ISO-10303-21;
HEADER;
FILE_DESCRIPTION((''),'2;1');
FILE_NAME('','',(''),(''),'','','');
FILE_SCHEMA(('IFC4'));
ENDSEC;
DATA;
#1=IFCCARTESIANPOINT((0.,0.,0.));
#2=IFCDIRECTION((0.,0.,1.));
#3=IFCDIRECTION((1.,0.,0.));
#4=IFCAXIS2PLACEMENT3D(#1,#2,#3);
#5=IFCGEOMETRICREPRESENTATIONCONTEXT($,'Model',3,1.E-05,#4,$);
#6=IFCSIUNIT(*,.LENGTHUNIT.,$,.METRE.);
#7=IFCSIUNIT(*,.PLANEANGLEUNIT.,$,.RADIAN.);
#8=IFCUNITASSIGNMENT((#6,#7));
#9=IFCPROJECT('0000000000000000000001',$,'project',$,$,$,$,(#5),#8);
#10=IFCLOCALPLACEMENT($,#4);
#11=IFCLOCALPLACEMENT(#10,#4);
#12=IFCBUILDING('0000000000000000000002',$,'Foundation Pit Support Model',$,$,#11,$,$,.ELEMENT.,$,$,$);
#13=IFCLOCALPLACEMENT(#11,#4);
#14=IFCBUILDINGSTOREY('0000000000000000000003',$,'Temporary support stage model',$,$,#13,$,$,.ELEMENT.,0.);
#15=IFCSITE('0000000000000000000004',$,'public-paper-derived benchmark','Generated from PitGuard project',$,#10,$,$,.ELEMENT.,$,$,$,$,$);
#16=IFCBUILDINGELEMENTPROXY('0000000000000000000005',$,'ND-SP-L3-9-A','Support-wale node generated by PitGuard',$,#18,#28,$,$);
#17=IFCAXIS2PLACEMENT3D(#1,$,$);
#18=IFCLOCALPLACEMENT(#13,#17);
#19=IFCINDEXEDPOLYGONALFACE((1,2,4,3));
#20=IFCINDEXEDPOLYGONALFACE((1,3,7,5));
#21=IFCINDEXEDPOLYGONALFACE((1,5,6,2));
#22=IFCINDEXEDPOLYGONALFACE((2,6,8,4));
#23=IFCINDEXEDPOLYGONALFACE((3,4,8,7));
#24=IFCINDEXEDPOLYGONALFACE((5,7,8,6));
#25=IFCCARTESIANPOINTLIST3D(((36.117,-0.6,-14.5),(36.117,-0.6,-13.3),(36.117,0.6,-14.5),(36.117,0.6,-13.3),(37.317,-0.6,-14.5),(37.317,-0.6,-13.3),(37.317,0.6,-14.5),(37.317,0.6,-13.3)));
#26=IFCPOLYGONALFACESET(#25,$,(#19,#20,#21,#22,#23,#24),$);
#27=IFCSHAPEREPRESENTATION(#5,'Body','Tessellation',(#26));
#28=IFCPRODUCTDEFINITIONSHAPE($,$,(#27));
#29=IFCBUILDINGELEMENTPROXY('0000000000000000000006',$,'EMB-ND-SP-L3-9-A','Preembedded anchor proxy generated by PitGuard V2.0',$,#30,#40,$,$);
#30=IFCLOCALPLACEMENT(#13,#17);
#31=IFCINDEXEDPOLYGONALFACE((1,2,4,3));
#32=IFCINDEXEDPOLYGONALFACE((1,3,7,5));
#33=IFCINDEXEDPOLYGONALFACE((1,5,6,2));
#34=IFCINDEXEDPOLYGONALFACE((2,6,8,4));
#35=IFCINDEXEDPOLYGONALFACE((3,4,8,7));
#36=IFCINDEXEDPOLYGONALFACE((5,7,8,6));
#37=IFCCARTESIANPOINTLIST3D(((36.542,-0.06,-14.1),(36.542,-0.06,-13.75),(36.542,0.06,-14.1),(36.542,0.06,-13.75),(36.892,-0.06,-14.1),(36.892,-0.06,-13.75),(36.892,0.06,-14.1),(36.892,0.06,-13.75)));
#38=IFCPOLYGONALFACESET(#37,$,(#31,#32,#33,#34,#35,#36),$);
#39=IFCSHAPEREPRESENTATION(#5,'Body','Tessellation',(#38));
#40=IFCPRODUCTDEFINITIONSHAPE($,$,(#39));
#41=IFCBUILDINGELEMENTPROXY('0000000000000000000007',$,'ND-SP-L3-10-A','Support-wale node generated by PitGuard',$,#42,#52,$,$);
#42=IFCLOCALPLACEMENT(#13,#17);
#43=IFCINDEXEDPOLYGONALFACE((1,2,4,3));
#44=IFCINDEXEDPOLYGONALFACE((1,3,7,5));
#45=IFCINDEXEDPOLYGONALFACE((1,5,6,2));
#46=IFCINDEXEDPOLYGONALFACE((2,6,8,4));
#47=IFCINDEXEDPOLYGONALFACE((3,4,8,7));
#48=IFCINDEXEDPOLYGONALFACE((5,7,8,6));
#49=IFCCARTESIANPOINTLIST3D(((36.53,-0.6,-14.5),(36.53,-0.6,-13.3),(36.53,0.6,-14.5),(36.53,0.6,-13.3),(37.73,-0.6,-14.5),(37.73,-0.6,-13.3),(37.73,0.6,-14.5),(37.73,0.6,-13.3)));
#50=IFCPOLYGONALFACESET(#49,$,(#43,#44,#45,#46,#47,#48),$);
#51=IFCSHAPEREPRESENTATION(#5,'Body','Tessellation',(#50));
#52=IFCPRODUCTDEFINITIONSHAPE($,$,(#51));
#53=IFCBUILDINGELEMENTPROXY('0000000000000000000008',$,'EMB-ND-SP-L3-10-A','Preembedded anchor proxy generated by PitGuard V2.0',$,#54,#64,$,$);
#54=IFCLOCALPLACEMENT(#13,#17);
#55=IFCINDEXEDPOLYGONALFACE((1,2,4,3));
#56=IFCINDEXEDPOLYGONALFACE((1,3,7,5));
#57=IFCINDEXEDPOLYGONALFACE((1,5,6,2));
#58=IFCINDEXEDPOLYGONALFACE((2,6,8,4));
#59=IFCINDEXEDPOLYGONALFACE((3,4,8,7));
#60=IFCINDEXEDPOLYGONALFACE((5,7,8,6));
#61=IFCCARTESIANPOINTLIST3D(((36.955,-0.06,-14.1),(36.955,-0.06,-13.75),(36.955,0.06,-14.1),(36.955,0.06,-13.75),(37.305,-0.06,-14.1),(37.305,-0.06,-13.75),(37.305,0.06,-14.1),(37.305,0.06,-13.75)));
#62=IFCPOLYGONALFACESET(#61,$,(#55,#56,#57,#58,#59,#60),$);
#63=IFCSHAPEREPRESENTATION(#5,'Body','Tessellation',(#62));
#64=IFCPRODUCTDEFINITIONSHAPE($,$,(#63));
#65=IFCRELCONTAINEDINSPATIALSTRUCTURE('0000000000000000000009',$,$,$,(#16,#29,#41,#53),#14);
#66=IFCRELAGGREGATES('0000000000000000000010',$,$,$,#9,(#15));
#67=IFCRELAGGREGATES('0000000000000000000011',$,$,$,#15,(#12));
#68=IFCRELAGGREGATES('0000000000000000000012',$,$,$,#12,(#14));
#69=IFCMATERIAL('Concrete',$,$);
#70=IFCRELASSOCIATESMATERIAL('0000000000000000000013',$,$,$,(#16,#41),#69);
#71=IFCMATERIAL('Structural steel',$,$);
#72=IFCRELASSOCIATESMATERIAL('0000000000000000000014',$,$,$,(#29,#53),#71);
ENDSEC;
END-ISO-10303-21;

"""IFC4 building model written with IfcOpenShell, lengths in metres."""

from ifc_helpers import new_model, si_unit, frame, origin_with_axes, origin_2d, place, context, project, spatial, rectangle, extrude, material, element, save


model = new_model("IFC4")

# Units and contexts
model_context = context("Model", 3, precision=1e-05, world=origin_with_axes())
ifc_project = project(units=[si_unit("LENGTHUNIT", "METRE"), si_unit("PLANEANGLEUNIT", "RADIAN")], contexts=[model_context])

# Site, building, storey
site_placement = place(None, origin_with_axes())
site = spatial("IfcSite", under=ifc_project, at=site_placement, Name="public-paper-derived benchmark", Description="Generated from PitGuard project", CompositionType="ELEMENT")
building_placement = place(site_placement, origin_with_axes())
building = spatial("IfcBuilding", under=site, at=building_placement, Name="Foundation Pit Support Model", CompositionType="ELEMENT")
storey_placement = place(building_placement, origin_with_axes())
storey = spatial("IfcBuildingStorey", under=building, at=storey_placement, Name="Temporary support stage model", CompositionType="ELEMENT", Elevation=0.0)

# Shared definitions
ifc_material_1 = material(Name="Structural steel")

# Shared definitions
ifc_material_2 = material(Name="Concrete")

# Building element proxies
proxy_1_placement = place(storey_placement, frame((36.717, 0.0, -14.5), z_axis=(0.0, 0.0, 1.0), x_axis=(1.0, 0.0, 0.0)))
element("IfcBuildingElementProxy", 1, at=proxy_1_placement, inside=storey, material=ifc_material_2, Name="ND-SP-L3-9-A", Description="Support-wale node generated by PitGuard", context=model_context, shape_type="SweptSolid", body=[
    extrude(rectangle(XDim=1.2, YDim=1.2, at=origin_2d()), origin_with_axes(), (0.0, 0.0, 1.0), 1.2),
])
proxy_2_placement = place(storey_placement, frame((36.717, 0.0, -14.1), z_axis=(0.0, 0.0, 1.0), x_axis=(1.0, 0.0, 0.0)))
element("IfcBuildingElementProxy", 2, at=proxy_2_placement, inside=storey, material=ifc_material_1, Name="EMB-ND-SP-L3-9-A", Description="Preembedded anchor proxy generated by PitGuard V2.0", context=model_context, shape_type="SweptSolid", body=[
    extrude(rectangle(XDim=0.35, YDim=0.12, at=origin_2d()), origin_with_axes(), (0.0, 0.0, 1.0), 0.35),
])
proxy_3_placement = place(storey_placement, frame((37.13, 0.0, -14.5), z_axis=(0.0, 0.0, 1.0), x_axis=(1.0, 0.0, 0.0)))
element("IfcBuildingElementProxy", 3, at=proxy_3_placement, inside=storey, material=ifc_material_2, Name="ND-SP-L3-10-A", Description="Support-wale node generated by PitGuard", context=model_context, shape_type="SweptSolid", body=[
    extrude(rectangle(XDim=1.2, YDim=1.2, at=origin_2d()), origin_with_axes(), (0.0, 0.0, 1.0), 1.2),
])
proxy_4_placement = place(storey_placement, frame((37.13, 0.0, -14.1), z_axis=(0.0, 0.0, 1.0), x_axis=(1.0, 0.0, 0.0)))
element("IfcBuildingElementProxy", 4, at=proxy_4_placement, inside=storey, material=ifc_material_1, Name="EMB-ND-SP-L3-10-A", Description="Preembedded anchor proxy generated by PitGuard V2.0", context=model_context, shape_type="SweptSolid", body=[
    extrude(rectangle(XDim=0.35, YDim=0.12, at=origin_2d()), origin_with_axes(), (0.0, 0.0, 1.0), 0.35),
])

save(model, "model.ifc")
